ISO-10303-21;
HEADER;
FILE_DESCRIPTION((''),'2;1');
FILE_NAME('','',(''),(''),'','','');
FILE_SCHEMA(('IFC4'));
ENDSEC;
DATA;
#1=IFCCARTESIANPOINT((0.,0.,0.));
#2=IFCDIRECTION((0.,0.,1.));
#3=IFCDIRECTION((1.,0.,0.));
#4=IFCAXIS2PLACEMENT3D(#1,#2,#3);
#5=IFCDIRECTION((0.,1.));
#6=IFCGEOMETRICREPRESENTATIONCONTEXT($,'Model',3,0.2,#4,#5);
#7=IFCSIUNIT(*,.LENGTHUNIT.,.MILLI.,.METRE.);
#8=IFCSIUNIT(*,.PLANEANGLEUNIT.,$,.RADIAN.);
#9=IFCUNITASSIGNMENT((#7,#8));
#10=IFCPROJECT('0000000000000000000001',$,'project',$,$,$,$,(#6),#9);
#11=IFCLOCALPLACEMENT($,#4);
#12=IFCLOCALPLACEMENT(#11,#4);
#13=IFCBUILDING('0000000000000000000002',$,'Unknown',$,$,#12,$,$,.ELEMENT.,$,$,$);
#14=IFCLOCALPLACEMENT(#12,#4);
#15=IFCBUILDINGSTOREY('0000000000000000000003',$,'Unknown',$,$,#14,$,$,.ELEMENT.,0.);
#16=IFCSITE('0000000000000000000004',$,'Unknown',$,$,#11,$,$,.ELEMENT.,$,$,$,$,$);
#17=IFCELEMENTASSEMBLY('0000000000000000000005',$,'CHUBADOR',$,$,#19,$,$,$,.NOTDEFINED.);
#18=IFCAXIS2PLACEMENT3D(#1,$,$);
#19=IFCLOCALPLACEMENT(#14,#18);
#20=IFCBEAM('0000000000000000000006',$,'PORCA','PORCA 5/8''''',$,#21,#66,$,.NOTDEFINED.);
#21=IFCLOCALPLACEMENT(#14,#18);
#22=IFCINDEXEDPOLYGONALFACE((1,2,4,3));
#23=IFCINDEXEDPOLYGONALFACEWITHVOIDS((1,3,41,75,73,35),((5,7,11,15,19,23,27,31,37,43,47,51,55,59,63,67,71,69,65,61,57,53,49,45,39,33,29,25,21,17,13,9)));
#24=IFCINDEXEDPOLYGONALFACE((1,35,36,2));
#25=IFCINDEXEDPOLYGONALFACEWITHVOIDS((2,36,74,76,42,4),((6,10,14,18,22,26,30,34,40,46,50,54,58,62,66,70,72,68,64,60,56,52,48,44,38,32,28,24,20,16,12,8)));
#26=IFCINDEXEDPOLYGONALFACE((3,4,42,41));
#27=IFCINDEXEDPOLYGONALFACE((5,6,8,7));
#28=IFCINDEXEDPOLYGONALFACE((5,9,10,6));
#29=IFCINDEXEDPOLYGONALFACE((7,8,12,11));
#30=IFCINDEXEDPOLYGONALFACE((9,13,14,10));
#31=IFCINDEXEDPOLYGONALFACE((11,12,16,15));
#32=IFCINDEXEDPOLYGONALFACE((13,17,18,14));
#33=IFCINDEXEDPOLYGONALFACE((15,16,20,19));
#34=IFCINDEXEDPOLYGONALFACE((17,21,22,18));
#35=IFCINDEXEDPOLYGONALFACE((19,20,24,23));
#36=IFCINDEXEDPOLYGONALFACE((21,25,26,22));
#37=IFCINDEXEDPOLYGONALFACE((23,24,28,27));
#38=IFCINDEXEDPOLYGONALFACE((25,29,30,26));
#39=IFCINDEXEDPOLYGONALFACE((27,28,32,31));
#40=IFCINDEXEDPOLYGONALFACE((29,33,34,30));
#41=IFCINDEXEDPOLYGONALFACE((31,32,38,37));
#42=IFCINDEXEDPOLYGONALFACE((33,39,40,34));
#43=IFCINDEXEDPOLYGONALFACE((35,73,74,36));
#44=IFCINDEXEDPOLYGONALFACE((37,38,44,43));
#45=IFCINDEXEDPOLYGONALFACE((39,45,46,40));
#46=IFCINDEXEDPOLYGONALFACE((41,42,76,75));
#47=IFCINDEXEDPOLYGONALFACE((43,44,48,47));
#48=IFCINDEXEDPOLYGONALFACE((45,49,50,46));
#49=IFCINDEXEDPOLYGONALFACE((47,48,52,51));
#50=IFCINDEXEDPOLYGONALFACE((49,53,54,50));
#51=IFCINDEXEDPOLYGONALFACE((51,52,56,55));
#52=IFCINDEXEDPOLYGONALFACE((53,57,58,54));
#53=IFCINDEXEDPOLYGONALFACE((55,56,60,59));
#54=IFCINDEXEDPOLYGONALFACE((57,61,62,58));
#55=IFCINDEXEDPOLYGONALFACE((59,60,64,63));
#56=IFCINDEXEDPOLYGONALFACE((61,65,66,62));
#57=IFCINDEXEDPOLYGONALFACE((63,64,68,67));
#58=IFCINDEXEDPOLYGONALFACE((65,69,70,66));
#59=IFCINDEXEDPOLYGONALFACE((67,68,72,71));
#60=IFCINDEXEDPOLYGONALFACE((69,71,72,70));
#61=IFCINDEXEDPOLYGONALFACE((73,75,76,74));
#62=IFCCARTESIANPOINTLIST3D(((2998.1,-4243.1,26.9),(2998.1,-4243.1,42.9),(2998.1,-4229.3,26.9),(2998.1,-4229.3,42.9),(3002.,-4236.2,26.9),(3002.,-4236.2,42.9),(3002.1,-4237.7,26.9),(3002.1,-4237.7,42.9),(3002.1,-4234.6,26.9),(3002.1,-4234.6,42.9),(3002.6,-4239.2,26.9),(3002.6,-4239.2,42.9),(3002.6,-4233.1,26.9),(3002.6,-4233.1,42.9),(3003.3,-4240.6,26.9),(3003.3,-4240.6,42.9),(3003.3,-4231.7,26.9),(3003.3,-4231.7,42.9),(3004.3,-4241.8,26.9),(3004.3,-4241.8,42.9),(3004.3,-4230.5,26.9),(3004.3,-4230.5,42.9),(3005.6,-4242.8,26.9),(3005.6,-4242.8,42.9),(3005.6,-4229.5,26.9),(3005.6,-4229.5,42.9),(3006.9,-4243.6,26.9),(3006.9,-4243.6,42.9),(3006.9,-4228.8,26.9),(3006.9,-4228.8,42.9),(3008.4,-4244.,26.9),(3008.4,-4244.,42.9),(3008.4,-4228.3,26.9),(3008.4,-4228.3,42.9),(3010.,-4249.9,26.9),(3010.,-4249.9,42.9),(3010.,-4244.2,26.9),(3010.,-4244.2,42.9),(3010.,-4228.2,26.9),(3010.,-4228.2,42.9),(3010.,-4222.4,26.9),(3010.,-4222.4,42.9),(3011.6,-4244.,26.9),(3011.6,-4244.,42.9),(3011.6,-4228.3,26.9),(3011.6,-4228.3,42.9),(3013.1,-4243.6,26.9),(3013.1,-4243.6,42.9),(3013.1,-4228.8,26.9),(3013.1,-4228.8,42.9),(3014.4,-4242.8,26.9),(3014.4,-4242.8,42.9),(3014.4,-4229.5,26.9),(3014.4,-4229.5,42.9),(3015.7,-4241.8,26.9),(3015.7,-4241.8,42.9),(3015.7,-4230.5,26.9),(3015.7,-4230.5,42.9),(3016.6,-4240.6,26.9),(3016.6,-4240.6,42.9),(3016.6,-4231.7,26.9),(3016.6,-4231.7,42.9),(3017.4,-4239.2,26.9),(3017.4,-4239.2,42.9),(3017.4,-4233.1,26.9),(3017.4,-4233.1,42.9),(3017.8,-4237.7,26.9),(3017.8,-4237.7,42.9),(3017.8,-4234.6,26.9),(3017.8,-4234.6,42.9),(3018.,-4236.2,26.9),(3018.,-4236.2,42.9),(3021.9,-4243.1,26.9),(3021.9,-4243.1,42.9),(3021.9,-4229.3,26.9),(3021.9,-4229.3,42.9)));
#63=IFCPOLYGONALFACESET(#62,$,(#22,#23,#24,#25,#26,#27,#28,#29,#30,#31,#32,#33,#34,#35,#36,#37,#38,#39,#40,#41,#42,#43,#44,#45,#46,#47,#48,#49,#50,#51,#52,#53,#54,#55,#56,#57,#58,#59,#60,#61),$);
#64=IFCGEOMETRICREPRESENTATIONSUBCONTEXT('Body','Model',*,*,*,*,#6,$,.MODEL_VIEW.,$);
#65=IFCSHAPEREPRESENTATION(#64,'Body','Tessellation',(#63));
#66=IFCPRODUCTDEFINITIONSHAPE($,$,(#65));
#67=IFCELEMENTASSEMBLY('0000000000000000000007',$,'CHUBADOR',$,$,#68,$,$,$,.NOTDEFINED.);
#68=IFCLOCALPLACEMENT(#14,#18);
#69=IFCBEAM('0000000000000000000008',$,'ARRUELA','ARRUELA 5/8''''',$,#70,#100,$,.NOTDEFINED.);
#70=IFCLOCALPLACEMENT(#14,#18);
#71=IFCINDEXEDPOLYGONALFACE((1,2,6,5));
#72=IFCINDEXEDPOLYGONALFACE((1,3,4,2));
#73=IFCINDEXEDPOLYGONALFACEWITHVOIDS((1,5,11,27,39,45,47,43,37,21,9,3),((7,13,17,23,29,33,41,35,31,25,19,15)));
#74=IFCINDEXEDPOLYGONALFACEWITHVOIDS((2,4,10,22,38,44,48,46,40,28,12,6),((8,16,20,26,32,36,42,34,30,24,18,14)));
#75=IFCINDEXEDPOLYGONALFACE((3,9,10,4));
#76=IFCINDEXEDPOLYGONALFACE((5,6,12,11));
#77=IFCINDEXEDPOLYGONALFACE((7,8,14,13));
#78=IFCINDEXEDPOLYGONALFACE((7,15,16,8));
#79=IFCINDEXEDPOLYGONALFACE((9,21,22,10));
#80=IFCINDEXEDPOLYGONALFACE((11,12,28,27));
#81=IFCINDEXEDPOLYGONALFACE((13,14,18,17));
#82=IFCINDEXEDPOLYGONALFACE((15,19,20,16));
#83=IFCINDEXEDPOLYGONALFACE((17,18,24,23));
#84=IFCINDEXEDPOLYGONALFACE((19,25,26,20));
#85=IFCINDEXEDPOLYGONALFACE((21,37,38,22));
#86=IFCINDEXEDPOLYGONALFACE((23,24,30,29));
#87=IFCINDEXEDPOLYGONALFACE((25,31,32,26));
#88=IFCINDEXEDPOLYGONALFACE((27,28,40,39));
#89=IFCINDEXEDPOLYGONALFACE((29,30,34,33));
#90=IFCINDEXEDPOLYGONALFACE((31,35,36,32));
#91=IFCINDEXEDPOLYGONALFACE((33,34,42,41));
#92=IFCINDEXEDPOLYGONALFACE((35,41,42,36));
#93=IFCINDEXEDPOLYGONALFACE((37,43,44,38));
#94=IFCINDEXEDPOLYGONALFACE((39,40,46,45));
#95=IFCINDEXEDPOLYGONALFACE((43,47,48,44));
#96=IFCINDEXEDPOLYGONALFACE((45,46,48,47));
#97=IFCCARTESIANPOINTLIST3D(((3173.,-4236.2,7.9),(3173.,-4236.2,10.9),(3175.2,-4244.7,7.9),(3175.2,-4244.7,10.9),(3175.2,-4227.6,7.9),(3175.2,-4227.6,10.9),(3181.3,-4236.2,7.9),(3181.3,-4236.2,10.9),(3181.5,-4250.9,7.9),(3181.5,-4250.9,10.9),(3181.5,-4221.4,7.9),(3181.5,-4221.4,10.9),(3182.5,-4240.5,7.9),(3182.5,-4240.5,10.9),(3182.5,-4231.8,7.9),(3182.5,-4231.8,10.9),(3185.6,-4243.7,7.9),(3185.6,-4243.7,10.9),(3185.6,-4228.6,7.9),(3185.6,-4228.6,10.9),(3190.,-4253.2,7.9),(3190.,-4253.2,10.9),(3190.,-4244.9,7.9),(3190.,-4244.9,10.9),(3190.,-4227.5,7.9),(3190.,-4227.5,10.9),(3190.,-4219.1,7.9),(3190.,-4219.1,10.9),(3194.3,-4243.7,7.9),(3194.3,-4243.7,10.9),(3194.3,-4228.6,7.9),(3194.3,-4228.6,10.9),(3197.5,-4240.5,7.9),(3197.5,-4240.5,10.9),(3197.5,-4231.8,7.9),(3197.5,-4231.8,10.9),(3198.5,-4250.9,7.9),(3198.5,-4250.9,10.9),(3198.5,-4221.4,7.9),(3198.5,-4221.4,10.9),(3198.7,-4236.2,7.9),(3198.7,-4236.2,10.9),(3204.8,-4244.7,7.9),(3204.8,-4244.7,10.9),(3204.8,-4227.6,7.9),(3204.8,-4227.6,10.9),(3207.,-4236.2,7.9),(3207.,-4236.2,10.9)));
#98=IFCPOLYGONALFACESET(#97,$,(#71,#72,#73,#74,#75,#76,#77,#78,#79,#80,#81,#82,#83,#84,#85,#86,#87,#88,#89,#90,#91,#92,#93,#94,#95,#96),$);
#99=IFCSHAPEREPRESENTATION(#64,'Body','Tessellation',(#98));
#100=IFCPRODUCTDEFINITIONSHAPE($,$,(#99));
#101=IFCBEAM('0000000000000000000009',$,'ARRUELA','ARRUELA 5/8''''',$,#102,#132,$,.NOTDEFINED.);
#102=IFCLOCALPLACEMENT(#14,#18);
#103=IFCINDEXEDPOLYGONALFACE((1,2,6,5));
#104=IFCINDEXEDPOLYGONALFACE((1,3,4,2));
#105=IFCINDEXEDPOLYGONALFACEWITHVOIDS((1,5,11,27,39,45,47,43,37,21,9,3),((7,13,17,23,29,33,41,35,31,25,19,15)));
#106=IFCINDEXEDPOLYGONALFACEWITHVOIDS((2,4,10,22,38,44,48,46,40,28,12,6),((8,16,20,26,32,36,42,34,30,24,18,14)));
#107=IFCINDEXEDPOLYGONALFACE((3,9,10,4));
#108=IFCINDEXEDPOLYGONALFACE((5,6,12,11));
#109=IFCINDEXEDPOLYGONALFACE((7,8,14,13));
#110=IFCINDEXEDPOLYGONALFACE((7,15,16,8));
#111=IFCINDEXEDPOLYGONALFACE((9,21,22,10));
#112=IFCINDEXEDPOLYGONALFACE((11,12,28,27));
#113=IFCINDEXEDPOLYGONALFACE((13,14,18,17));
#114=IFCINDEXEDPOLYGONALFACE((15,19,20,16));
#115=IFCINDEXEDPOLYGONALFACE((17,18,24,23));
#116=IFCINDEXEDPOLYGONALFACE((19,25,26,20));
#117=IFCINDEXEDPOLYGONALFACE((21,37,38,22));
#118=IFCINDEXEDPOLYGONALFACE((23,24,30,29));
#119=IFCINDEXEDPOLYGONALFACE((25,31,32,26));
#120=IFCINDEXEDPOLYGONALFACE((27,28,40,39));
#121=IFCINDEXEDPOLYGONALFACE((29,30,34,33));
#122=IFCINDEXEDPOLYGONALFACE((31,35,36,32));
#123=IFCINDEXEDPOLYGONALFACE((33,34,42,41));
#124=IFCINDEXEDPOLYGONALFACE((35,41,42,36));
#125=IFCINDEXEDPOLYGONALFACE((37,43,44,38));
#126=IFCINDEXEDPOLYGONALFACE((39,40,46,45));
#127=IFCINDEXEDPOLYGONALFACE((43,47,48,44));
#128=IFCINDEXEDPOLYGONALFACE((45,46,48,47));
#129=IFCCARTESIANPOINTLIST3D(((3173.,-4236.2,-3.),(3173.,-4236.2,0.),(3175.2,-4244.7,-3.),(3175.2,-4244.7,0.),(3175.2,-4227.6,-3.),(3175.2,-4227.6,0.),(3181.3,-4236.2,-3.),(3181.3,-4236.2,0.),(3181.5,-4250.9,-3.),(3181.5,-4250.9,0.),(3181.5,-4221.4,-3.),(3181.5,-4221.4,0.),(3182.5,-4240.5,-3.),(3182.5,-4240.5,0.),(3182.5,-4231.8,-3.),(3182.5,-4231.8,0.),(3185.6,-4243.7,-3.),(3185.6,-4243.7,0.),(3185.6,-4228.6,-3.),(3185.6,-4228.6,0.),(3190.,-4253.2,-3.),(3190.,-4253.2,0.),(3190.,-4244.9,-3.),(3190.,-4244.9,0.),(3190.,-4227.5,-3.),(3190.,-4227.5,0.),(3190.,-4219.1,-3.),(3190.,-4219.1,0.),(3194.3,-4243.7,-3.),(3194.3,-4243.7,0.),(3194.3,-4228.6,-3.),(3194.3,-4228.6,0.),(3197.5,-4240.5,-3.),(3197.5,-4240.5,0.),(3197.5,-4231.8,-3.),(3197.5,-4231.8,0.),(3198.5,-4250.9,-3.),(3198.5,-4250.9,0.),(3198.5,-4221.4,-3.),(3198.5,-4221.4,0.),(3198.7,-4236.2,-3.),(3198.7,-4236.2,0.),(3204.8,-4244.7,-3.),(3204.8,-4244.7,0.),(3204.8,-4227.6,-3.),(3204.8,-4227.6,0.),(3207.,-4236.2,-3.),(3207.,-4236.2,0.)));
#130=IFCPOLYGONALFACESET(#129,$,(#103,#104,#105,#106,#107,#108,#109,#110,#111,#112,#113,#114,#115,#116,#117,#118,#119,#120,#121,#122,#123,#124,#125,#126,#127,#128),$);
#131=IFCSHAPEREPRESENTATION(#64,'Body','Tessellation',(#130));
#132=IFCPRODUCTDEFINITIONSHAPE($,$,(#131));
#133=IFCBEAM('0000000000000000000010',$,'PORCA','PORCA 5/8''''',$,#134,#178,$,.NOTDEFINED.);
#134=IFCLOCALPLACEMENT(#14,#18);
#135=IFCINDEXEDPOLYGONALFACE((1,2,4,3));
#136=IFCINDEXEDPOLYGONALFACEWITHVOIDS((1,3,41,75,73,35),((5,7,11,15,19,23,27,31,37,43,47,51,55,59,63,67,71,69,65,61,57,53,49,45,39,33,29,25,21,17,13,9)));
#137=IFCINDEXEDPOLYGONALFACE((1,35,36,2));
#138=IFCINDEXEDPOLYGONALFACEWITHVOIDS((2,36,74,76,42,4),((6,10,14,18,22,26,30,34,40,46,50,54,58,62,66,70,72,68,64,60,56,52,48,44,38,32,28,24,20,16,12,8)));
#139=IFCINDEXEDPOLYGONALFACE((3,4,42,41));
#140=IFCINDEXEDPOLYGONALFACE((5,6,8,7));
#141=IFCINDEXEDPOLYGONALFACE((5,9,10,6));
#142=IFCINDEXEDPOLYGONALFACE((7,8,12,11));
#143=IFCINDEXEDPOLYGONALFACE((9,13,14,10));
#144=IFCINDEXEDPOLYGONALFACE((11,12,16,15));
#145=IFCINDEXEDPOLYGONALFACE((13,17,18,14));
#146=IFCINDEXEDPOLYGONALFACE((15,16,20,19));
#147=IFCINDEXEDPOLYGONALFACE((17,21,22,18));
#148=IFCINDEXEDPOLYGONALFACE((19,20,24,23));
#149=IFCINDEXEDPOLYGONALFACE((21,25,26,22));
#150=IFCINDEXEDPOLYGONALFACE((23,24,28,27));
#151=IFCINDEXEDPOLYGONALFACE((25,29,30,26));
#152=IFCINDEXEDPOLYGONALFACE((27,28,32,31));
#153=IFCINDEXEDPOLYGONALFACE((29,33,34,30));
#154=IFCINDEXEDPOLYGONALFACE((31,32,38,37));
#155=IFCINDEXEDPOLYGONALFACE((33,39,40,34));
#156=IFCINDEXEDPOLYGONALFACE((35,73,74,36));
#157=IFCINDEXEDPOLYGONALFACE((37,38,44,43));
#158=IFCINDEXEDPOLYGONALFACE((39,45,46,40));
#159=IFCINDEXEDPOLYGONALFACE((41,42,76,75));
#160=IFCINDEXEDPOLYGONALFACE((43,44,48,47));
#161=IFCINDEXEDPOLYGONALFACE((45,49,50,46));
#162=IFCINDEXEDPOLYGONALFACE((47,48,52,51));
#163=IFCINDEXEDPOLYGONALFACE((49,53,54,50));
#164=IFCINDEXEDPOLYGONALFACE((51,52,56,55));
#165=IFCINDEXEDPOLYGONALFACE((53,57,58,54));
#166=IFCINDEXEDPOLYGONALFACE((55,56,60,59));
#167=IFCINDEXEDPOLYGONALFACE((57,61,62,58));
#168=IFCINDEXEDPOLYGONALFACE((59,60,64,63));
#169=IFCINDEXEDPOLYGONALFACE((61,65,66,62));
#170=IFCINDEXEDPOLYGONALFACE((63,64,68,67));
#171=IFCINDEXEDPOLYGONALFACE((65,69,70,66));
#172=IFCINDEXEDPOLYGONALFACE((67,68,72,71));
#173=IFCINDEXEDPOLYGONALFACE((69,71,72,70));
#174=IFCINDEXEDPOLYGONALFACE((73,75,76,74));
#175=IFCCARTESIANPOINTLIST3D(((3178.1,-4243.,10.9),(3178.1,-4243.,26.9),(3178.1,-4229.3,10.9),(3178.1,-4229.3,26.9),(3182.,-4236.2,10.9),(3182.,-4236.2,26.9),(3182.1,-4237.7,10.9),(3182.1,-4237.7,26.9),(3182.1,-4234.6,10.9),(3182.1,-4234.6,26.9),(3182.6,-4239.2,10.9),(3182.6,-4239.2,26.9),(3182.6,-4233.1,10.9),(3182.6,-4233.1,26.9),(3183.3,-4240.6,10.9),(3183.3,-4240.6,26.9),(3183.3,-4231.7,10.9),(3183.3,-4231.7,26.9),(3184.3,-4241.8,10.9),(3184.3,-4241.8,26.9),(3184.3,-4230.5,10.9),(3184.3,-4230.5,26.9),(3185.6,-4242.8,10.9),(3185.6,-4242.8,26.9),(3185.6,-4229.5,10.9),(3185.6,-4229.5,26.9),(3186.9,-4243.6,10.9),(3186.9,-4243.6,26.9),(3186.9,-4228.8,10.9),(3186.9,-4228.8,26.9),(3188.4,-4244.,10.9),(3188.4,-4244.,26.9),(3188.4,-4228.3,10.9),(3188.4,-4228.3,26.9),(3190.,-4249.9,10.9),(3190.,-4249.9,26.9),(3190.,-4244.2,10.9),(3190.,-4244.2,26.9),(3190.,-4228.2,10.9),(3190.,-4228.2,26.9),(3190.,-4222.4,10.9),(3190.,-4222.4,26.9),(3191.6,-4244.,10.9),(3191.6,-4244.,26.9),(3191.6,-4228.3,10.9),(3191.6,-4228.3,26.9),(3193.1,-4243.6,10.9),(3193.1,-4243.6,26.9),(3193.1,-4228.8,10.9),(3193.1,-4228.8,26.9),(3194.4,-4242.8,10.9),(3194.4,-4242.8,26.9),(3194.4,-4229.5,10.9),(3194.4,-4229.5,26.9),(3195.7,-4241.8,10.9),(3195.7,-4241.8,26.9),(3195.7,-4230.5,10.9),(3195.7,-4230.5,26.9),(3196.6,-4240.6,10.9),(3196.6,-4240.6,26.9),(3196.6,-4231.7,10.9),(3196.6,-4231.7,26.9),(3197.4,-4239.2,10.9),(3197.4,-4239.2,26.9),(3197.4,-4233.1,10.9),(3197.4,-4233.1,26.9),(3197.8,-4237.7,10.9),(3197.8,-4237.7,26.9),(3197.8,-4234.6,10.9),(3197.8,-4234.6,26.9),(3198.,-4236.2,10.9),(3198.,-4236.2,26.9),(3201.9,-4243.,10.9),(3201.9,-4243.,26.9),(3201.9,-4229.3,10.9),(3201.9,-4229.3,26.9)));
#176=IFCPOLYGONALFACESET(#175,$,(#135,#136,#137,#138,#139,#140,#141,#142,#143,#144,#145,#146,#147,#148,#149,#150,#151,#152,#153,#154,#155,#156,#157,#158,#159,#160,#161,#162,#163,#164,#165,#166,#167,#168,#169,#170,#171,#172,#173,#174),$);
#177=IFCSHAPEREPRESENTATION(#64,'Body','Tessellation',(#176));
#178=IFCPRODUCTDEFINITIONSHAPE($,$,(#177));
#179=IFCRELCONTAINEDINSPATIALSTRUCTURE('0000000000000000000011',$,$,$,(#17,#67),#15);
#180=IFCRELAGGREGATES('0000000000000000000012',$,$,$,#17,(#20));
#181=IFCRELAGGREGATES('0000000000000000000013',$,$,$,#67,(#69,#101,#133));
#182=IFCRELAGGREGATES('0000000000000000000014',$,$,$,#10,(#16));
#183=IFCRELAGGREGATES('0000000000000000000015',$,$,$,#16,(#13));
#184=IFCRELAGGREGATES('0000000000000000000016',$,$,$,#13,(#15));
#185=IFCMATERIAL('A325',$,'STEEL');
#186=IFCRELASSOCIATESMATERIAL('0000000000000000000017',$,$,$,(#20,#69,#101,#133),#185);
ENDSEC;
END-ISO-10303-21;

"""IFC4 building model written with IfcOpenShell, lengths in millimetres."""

from ifc_helpers import new_model, si_unit, direction, frame, origin_with_axes, place, context, subcontext, project, spatial, line, indexed_curve, outline, extrude, material, element, aggregate, save


model = new_model("IFC4")

# Units and contexts
model_context = context("Model", 3, precision=0.2, world=origin_with_axes(), true_north=direction((0.0, 1.0)))
body_context = subcontext(model_context, "Body", "Model", "MODEL_VIEW")
ifc_project = project(units=[si_unit("LENGTHUNIT", "METRE", prefix="MILLI"), si_unit("PLANEANGLEUNIT", "RADIAN")], contexts=[model_context])

# Site, building, storey
site_placement = place(None, origin_with_axes())
site = spatial("IfcSite", under=ifc_project, at=site_placement, Name="Unknown", CompositionType="ELEMENT")
building_placement = place(site_placement, origin_with_axes())
building = spatial("IfcBuilding", under=site, at=building_placement, Name="Unknown", CompositionType="ELEMENT")
storey_placement = place(building_placement, origin_with_axes())
storey = spatial("IfcBuildingStorey", under=building, at=storey_placement, Name="Unknown", CompositionType="ELEMENT", Elevation=0.0)

# Element assemblies, beams
ifc_material_1 = material(Name="A325", Category="STEEL")
assembly_1_placement = place(storey_placement, frame((3010.0, -4236.2, -52.1), z_axis=(-1.0, 0.0, 0.0), x_axis=(0.0, 0.0, -1.0)))
assembly_1 = element("IfcElementAssembly", 1, at=assembly_1_placement, inside=storey, Name="CHUBADOR", PredefinedType="NOTDEFINED")
beam_1_placement = place(assembly_1_placement, frame((-95.0, 0.0, 0.0), z_axis=(0.0, 0.0, 1.0), x_axis=(1.0, 0.0, 0.0)))
beam_1 = element("IfcBeam", 2, at=beam_1_placement, material=ifc_material_1, Name="PORCA", Description="PORCA 5/8''", PredefinedType="NOTDEFINED", context=body_context, shape_type="SolidModel", body=[
    extrude(outline(indexed_curve([(0.0, 13.8), (-11.9, 6.9), (-11.9, -6.9), (0.0, -13.8), (11.9, -6.9), (11.9, 6.9)], segments=[line(1, 2, 3, 4, 5, 6, 1)]), holes=[indexed_curve([(7.8, 1.6), (8.0, 0.0), (7.8, -1.6), (7.4, -3.1), (6.7, -4.4), (5.7, -5.7), (4.4, -6.7), (3.1, -7.4), (1.6, -7.8), (0.0, -8.0), (-1.6, -7.8), (-3.1, -7.4), (-4.4, -6.7), (-5.7, -5.7), (-6.7, -4.4), (-7.4, -3.1), (-7.8, -1.6), (-8.0, 0.0), (-7.8, 1.6), (-7.4, 3.1), (-6.7, 4.4), (-5.7, 5.7), (-4.4, 6.7), (-3.1, 7.4), (-1.6, 7.8), (0.0, 8.0), (1.6, 7.8), (3.1, 7.4), (4.4, 6.7), (5.7, 5.7), (6.7, 4.4), (7.4, 3.1)], segments=[line(1, 2, 3, 4, 5, 6, 7, 8, 9, 10, 11, 12, 13, 14, 15, 16, 17, 18, 19, 20, 21, 22, 23, 24, 25, 26, 27, 28, 29, 30, 31, 32, 1)])]), frame((0.0, 0.0, 0.0), z_axis=(-1.0, 0.0, 0.0), x_axis=(0.0, 0.0, 1.0)), (0.0, 0.0, -1.0), 16.0),
])
aggregate(assembly_1, [beam_1])
assembly_2_placement = place(storey_placement, frame((3190.0, -4236.2, -52.1), z_axis=(1.0, 0.0, 0.0), x_axis=(0.0, 0.0, -1.0)))
assembly_2 = element("IfcElementAssembly", 3, at=assembly_2_placement, inside=storey, Name="CHUBADOR", PredefinedType="NOTDEFINED")
beam_2_placement = place(assembly_2_placement, frame((-63.0, 0.0, 0.0), z_axis=(0.0, 0.0, 1.0), x_axis=(1.0, 0.0, 0.0)))
beam_2 = element("IfcBeam", 4, at=beam_2_placement, material=ifc_material_1, Name="ARRUELA", Description="ARRUELA 5/8''", PredefinedType="NOTDEFINED", context=body_context, shape_type="SolidModel", body=[
    extrude(outline(indexed_curve([(17.0, 0.0), (14.8, 8.5), (8.5, 14.8), (0.0, 17.0), (-8.5, 14.8), (-14.8, 8.5), (-17.0, 0.0), (-14.8, -8.5), (-8.5, -14.8), (0.0, -17.0), (8.5, -14.8), (14.8, -8.5)], segments=[line(1, 2, 3, 4, 5, 6, 7, 8, 9, 10, 11, 12, 1)]), holes=[indexed_curve([(8.7, 0.0), (7.5, -4.3), (4.3, -7.5), (0.0, -8.7), (-4.3, -7.5), (-7.5, -4.3), (-8.7, 0.0), (-7.5, 4.3), (-4.3, 7.5), (0.0, 8.7), (4.3, 7.5), (7.5, 4.3)], segments=[line(1, 2, 3, 4, 5, 6, 7, 8, 9, 10, 11, 12, 1)])]), frame((0.0, 0.0, 0.0), z_axis=(-1.0, 0.0, 0.0), x_axis=(0.0, 0.0, 1.0)), (0.0, 0.0, -1.0), 3.0),
])
beam_3_placement = place(assembly_2_placement, frame((-52.1, 0.0, 0.0), z_axis=(0.0, 0.0, 1.0), x_axis=(1.0, 0.0, 0.0)))
beam_3 = element("IfcBeam", 5, at=beam_3_placement, material=ifc_material_1, Name="ARRUELA", Description="ARRUELA 5/8''", PredefinedType="NOTDEFINED", context=body_context, shape_type="SolidModel", body=[
    extrude(outline(indexed_curve([(17.0, 0.0), (14.8, 8.5), (8.5, 14.8), (0.0, 17.0), (-8.5, 14.8), (-14.8, 8.5), (-17.0, 0.0), (-14.8, -8.5), (-8.5, -14.8), (0.0, -17.0), (8.5, -14.8), (14.8, -8.5)], segments=[line(1, 2, 3, 4, 5, 6, 7, 8, 9, 10, 11, 12, 1)]), holes=[indexed_curve([(8.7, 0.0), (7.5, -4.3), (4.3, -7.5), (0.0, -8.7), (-4.3, -7.5), (-7.5, -4.3), (-8.7, 0.0), (-7.5, 4.3), (-4.3, 7.5), (0.0, 8.7), (4.3, 7.5), (7.5, 4.3)], segments=[line(1, 2, 3, 4, 5, 6, 7, 8, 9, 10, 11, 12, 1)])]), frame((0.0, 0.0, 0.0), z_axis=(-1.0, 0.0, 0.0), x_axis=(0.0, 0.0, 1.0)), (0.0, 0.0, -1.0), 3.0),
])
beam_4_placement = place(assembly_2_placement, frame((-79.0, 0.0, 0.0), z_axis=(0.0, 0.0, 1.0), x_axis=(1.0, 0.0, 0.0)))
beam_4 = element("IfcBeam", 6, at=beam_4_placement, material=ifc_material_1, Name="PORCA", Description="PORCA 5/8''", PredefinedType="NOTDEFINED", context=body_context, shape_type="SolidModel", body=[
    extrude(outline(indexed_curve([(0.0, 13.8), (-11.9, 6.9), (-11.9, -6.9), (0.0, -13.8), (11.9, -6.9), (11.9, 6.9)], segments=[line(1, 2, 3, 4, 5, 6, 1)]), holes=[indexed_curve([(7.8, 1.6), (8.0, 0.0), (7.8, -1.6), (7.4, -3.1), (6.7, -4.4), (5.7, -5.7), (4.4, -6.7), (3.1, -7.4), (1.6, -7.8), (0.0, -8.0), (-1.6, -7.8), (-3.1, -7.4), (-4.4, -6.7), (-5.7, -5.7), (-6.7, -4.4), (-7.4, -3.1), (-7.8, -1.6), (-8.0, 0.0), (-7.8, 1.6), (-7.4, 3.1), (-6.7, 4.4), (-5.7, 5.7), (-4.4, 6.7), (-3.1, 7.4), (-1.6, 7.8), (0.0, 8.0), (1.6, 7.8), (3.1, 7.4), (4.4, 6.7), (5.7, 5.7), (6.7, 4.4), (7.4, 3.1)], segments=[line(1, 2, 3, 4, 5, 6, 7, 8, 9, 10, 11, 12, 13, 14, 15, 16, 17, 18, 19, 20, 21, 22, 23, 24, 25, 26, 27, 28, 29, 30, 31, 32, 1)])]), frame((0.0, 0.0, 0.0), z_axis=(-1.0, 0.0, 0.0), x_axis=(0.0, 0.0, 1.0)), (0.0, 0.0, -1.0), 16.0),
])
aggregate(assembly_2, [beam_2, beam_3, beam_4])

save(model, "model.ifc")
